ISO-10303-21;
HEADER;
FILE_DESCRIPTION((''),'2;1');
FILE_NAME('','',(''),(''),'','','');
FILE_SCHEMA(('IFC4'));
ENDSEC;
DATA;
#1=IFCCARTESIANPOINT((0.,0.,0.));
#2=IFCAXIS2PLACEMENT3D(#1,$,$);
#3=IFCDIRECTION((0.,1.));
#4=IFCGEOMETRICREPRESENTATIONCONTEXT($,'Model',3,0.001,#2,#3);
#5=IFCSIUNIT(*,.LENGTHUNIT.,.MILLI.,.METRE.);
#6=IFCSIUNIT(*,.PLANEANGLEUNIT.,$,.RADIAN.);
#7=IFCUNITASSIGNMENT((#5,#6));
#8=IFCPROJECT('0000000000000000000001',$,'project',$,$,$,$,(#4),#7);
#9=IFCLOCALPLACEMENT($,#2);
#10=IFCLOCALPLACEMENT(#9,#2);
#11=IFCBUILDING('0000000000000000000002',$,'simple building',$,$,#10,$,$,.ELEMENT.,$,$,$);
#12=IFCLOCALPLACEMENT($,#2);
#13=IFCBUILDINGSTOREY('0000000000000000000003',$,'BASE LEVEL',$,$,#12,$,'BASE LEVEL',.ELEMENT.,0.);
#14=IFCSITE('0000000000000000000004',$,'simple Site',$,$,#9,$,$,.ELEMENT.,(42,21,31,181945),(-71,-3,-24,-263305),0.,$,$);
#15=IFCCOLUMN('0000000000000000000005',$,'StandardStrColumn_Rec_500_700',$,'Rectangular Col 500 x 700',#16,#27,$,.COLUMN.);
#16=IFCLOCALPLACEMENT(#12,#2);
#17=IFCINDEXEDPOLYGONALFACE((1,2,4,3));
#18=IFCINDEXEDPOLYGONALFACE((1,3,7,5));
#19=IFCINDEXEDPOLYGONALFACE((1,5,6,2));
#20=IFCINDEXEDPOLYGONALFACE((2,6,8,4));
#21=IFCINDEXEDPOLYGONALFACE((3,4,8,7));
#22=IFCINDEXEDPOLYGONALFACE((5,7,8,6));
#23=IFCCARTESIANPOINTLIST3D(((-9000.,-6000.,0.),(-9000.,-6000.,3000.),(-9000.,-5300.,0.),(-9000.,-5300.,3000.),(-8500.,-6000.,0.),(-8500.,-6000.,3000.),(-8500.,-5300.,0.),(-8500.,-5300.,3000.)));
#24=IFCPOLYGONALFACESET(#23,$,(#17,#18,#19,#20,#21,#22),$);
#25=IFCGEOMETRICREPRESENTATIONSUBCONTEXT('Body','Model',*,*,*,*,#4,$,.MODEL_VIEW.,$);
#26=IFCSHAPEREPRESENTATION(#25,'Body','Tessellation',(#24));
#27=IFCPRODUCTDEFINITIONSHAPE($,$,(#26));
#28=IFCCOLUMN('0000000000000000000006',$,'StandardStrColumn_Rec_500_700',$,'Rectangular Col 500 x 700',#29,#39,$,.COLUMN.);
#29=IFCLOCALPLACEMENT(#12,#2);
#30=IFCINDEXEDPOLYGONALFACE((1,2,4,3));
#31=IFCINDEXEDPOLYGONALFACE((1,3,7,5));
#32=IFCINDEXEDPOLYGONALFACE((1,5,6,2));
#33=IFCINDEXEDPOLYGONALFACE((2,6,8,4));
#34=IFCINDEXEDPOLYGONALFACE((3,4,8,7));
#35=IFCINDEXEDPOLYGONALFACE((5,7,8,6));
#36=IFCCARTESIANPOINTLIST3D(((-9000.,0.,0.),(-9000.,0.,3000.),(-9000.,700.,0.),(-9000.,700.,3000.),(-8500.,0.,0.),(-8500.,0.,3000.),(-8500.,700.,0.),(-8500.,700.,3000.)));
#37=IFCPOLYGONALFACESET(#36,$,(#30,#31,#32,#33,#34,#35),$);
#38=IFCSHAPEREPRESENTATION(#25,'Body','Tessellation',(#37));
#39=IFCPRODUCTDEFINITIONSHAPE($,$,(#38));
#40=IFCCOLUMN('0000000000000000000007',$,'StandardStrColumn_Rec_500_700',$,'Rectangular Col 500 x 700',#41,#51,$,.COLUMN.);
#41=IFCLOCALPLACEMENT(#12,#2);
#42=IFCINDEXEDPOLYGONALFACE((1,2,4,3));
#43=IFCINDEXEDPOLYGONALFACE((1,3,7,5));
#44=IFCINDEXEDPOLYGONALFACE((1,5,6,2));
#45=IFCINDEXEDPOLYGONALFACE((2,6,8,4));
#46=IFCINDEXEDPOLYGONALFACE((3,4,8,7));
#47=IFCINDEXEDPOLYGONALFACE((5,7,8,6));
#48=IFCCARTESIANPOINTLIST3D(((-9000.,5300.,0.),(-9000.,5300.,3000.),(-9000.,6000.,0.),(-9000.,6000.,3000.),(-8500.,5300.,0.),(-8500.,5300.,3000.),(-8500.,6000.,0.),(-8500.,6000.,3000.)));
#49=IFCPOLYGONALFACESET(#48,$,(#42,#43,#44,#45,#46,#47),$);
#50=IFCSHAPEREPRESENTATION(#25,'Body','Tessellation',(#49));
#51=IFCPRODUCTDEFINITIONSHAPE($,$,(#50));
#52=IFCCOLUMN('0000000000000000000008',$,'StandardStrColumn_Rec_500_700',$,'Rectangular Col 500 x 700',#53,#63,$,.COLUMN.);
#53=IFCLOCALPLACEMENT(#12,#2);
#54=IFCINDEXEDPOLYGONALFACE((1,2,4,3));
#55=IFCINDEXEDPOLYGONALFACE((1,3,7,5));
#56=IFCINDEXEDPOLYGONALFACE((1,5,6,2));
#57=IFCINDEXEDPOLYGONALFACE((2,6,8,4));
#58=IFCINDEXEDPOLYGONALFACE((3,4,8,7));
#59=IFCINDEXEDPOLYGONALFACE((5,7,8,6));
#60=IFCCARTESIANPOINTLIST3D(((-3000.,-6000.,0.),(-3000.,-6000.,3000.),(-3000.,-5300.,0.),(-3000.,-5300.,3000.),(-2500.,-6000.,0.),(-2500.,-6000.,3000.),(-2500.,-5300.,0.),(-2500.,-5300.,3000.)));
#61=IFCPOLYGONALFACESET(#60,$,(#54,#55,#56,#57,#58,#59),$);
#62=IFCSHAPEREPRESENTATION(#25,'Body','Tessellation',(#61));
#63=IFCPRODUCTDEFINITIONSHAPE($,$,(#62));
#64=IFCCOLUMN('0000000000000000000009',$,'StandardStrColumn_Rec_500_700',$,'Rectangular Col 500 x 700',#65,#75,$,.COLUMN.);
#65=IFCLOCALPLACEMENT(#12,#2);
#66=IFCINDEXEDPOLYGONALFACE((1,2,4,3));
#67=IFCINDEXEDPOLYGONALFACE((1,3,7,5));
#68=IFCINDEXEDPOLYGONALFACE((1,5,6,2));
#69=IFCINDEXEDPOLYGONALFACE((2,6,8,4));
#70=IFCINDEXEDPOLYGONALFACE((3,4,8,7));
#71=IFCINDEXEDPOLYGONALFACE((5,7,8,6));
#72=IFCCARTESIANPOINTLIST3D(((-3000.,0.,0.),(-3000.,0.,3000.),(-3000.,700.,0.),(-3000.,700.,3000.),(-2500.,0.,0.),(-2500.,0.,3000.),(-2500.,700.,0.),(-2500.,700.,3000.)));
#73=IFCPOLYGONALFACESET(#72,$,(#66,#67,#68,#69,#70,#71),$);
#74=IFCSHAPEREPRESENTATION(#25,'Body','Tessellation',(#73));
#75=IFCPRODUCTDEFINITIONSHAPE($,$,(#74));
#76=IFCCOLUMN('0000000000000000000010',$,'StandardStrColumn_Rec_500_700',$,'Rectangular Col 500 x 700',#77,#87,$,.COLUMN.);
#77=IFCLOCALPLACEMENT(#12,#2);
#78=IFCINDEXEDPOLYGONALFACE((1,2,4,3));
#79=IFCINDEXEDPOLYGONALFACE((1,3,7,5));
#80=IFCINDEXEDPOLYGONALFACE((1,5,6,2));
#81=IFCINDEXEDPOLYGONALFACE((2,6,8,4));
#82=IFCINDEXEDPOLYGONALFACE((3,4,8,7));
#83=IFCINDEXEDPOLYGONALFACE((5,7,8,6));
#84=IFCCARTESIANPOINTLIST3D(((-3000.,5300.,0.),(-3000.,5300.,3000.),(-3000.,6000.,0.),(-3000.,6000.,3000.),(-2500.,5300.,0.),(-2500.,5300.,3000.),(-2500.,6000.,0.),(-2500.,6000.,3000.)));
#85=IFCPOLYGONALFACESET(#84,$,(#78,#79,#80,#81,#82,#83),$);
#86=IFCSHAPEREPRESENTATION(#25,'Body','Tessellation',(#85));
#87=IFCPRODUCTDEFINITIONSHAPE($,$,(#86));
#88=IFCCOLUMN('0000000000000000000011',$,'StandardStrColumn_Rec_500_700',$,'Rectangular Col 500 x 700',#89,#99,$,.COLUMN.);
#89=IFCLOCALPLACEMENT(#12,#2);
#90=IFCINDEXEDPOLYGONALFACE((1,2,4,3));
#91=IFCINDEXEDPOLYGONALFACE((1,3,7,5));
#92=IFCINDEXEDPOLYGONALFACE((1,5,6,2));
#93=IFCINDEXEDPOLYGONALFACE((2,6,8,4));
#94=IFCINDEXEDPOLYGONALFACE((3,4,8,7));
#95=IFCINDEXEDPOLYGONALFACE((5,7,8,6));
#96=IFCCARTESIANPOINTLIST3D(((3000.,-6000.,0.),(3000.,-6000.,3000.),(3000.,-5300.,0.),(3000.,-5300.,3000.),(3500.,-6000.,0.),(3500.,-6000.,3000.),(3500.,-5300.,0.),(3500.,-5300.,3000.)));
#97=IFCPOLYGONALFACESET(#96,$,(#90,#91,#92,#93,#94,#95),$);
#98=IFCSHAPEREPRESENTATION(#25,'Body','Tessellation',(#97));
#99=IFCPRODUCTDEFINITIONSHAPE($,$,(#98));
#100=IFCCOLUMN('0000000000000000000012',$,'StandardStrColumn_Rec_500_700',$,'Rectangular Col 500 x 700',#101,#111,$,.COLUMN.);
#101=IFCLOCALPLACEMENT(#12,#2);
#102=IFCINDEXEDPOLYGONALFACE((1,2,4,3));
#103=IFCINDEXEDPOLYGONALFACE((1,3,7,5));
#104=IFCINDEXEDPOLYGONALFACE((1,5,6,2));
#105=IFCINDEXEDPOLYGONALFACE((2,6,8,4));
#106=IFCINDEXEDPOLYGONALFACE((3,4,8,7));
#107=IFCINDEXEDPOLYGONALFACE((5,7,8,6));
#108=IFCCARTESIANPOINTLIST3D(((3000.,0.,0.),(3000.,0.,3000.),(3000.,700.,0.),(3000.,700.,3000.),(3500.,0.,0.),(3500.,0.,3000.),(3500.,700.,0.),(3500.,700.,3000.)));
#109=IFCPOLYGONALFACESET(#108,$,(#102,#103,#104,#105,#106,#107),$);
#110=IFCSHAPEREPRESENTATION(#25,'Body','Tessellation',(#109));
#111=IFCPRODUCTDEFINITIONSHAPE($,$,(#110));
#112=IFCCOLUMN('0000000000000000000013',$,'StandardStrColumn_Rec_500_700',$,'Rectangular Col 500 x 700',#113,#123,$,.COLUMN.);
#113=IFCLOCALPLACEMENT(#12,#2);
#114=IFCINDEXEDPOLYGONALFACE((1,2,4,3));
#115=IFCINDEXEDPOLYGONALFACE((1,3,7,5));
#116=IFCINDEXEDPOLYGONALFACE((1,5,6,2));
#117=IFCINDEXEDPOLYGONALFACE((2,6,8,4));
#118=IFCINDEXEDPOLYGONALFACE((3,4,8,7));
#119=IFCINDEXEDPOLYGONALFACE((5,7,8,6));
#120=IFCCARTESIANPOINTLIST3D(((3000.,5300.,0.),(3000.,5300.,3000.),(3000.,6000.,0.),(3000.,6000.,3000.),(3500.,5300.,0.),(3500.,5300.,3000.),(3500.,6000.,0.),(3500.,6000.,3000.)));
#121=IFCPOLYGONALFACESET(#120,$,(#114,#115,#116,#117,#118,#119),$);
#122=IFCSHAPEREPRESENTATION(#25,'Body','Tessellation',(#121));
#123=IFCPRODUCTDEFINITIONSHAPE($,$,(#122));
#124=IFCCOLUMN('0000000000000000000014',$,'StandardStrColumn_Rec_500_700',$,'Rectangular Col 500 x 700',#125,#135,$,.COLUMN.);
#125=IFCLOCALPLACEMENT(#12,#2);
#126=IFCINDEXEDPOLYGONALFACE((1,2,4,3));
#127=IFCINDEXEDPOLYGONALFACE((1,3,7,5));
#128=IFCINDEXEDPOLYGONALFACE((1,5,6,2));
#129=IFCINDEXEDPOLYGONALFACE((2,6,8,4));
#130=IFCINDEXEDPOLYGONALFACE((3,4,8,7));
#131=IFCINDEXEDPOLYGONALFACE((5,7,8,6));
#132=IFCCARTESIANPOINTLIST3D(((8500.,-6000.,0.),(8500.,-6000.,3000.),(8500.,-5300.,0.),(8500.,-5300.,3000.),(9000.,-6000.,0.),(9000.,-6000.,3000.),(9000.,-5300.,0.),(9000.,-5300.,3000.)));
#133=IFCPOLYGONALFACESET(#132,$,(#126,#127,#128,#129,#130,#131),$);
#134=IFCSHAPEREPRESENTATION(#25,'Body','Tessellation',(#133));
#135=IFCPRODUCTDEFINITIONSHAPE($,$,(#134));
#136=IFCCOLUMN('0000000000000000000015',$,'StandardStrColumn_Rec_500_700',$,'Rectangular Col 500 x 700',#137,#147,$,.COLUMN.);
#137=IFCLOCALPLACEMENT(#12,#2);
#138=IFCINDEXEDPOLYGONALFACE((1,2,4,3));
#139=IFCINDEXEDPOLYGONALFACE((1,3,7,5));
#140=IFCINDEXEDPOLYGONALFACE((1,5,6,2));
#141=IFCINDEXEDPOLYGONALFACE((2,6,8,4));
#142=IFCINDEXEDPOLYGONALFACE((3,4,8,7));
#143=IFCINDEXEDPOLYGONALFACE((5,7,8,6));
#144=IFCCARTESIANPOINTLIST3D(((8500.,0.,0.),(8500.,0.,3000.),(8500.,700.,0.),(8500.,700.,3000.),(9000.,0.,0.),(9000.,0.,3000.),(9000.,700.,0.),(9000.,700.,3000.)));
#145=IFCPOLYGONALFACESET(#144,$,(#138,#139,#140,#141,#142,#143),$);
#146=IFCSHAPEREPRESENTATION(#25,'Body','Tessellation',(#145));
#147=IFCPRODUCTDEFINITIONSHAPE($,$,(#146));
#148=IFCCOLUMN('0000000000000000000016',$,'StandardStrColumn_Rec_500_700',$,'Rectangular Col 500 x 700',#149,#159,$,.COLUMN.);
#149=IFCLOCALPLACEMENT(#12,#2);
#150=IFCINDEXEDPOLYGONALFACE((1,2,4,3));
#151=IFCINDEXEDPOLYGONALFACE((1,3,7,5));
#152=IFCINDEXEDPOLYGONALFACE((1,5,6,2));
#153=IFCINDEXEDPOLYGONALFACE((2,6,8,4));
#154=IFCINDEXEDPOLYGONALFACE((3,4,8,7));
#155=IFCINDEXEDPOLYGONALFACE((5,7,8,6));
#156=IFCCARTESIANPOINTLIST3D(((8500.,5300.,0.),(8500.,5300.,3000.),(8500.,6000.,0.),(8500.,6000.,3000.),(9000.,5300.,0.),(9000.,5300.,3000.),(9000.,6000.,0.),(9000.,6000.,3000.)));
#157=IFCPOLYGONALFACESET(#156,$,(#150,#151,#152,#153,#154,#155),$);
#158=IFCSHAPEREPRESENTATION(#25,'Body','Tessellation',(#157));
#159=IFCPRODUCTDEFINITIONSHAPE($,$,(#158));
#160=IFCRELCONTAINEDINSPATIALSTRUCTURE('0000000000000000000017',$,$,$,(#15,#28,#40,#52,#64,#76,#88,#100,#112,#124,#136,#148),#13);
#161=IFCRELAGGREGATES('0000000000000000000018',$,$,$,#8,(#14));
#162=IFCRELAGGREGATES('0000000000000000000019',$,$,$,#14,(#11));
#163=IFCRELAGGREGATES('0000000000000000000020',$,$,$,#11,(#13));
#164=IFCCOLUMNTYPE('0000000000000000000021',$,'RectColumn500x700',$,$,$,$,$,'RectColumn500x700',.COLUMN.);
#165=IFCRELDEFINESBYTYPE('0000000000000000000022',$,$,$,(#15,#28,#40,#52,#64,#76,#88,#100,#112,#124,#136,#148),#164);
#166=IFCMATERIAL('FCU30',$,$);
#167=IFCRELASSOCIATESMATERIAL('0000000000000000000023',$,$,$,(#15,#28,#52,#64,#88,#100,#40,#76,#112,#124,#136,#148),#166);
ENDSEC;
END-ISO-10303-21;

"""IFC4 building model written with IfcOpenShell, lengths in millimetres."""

from ifc_helpers import new_model, si_unit, direction, frame, origin, origin_with_axes, origin_2d_with_axis, place, context, subcontext, project, spatial, rectangle, extrude, material, material_profile, profile_set, profile_usage, type_object, element, save


model = new_model("IFC4")

# Units and contexts
model_context = context("Model", 3, precision=0.001, world=origin(), true_north=direction((0.0, 1.0)))
body_context = subcontext(model_context, "Body", "Model", "MODEL_VIEW")
ifc_project = project(units=[si_unit("LENGTHUNIT", "METRE", prefix="MILLI"), si_unit("PLANEANGLEUNIT", "RADIAN")], contexts=[model_context])

# Site, building, storey
site_placement = place(None, origin())
site = spatial("IfcSite", under=ifc_project, at=site_placement, Name="simple Site", CompositionType="ELEMENT", RefLatitude=(42, 21, 31, 181945), RefLongitude=(-71, -3, -24, -263305), RefElevation=0.0)
building_placement = place(site_placement, origin())
building = spatial("IfcBuilding", under=site, at=building_placement, Name="simple building", CompositionType="ELEMENT")
storey_placement = place(None, origin())
storey = spatial("IfcBuildingStorey", under=building, at=storey_placement, Name="BASE LEVEL", LongName="BASE LEVEL", CompositionType="ELEMENT", Elevation=0.0)

# Columns
ifc_material = material(Name="FCU30")
ifc_material_profile = material_profile(ifc_material, rectangle(XDim=500.0, YDim=700.0, at=origin_2d_with_axis()))
ifc_profile_set = profile_set([ifc_material_profile])
ifc_profile_usage_1 = profile_usage(ifc_profile_set, cardinal=7)
column_type = type_object("IfcColumnType", Name="RectColumn500x700", ElementType="RectColumn500x700", PredefinedType="COLUMN")
for number, where, z_axis, x_axis, name in (
    (1, (-8750.0, -5650.0, 0.0), (0.0, 0.0, 1.0), (1.0, 0.0, 0.0), "StandardStrColumn_Rec_500_700"),
    (2, (-8750.0, 350.0, 0.0), (0.0, 0.0, 1.0), (1.0, 0.0, 0.0), "StandardStrColumn_Rec_500_700"),
):
    element("IfcColumn", number, at=place(None, frame(where, z_axis=z_axis, x_axis=x_axis)), inside=storey, type_object=column_type, material=ifc_profile_usage_1, Name=name, ObjectType="Rectangular Col 500 x 700", PredefinedType="COLUMN", context=body_context, shape_type="SweptSolid", body=[
        extrude(rectangle(XDim=500.0, YDim=700.0, at=origin_2d_with_axis()), origin_with_axes(), (0.0, 0.0, 1.0), 3000.0),
    ])
ifc_profile_usage_2 = profile_usage(ifc_profile_set, cardinal=1)
column_1_placement = place(None, frame((-8750.0, 5650.0, 0.0), z_axis=(0.0, 0.0, 1.0), x_axis=(1.0, 0.0, 0.0)))
element("IfcColumn", 3, at=column_1_placement, inside=storey, type_object=column_type, material=ifc_profile_usage_2, Name="StandardStrColumn_Rec_500_700", ObjectType="Rectangular Col 500 x 700", PredefinedType="COLUMN", context=body_context, shape_type="SweptSolid", body=[
    extrude(rectangle(XDim=500.0, YDim=700.0, at=origin_2d_with_axis()), origin_with_axes(), (0.0, 0.0, 1.0), 3000.0),
])
for number, where, z_axis, x_axis, name in (
    (4, (-2750.0, -5650.0, 0.0), (0.0, 0.0, 1.0), (1.0, 0.0, 0.0), "StandardStrColumn_Rec_500_700"),
    (5, (-2750.0, 350.0, 0.0), (0.0, 0.0, 1.0), (1.0, 0.0, 0.0), "StandardStrColumn_Rec_500_700"),
):
    element("IfcColumn", number, at=place(None, frame(where, z_axis=z_axis, x_axis=x_axis)), inside=storey, type_object=column_type, material=ifc_profile_usage_1, Name=name, ObjectType="Rectangular Col 500 x 700", PredefinedType="COLUMN", context=body_context, shape_type="SweptSolid", body=[
        extrude(rectangle(XDim=500.0, YDim=700.0, at=origin_2d_with_axis()), origin_with_axes(), (0.0, 0.0, 1.0), 3000.0),
    ])
column_2_placement = place(None, frame((-2750.0, 5650.0, 0.0), z_axis=(0.0, 0.0, 1.0), x_axis=(1.0, 0.0, 0.0)))
element("IfcColumn", 6, at=column_2_placement, inside=storey, type_object=column_type, material=ifc_profile_usage_2, Name="StandardStrColumn_Rec_500_700", ObjectType="Rectangular Col 500 x 700", PredefinedType="COLUMN", context=body_context, shape_type="SweptSolid", body=[
    extrude(rectangle(XDim=500.0, YDim=700.0, at=origin_2d_with_axis()), origin_with_axes(), (0.0, 0.0, 1.0), 3000.0),
])
for number, where, z_axis, x_axis, name in (
    (7, (3250.0, -5650.0, 0.0), (0.0, 0.0, 1.0), (1.0, 0.0, 0.0), "StandardStrColumn_Rec_500_700"),
    (8, (3250.0, 350.0, 0.0), (0.0, 0.0, 1.0), (1.0, 0.0, 0.0), "StandardStrColumn_Rec_500_700"),
):
    element("IfcColumn", number, at=place(None, frame(where, z_axis=z_axis, x_axis=x_axis)), inside=storey, type_object=column_type, material=ifc_profile_usage_1, Name=name, ObjectType="Rectangular Col 500 x 700", PredefinedType="COLUMN", context=body_context, shape_type="SweptSolid", body=[
        extrude(rectangle(XDim=500.0, YDim=700.0, at=origin_2d_with_axis()), origin_with_axes(), (0.0, 0.0, 1.0), 3000.0),
    ])
column_3_placement = place(None, frame((3250.0, 5650.0, 0.0), z_axis=(0.0, 0.0, 1.0), x_axis=(1.0, 0.0, 0.0)))
element("IfcColumn", 9, at=column_3_placement, inside=storey, type_object=column_type, material=ifc_profile_usage_2, Name="StandardStrColumn_Rec_500_700", ObjectType="Rectangular Col 500 x 700", PredefinedType="COLUMN", context=body_context, shape_type="SweptSolid", body=[
    extrude(rectangle(XDim=500.0, YDim=700.0, at=origin_2d_with_axis()), origin_with_axes(), (0.0, 0.0, 1.0), 3000.0),
])
ifc_profile_usage_3 = profile_usage(ifc_profile_set, cardinal=9)
for number, where, z_axis, x_axis, name in (
    (10, (8750.0, -5650.0, 0.0), (0.0, 0.0, 1.0), (1.0, 0.0, 0.0), "StandardStrColumn_Rec_500_700"),
    (11, (8750.0, 350.0, 0.0), (0.0, 0.0, 1.0), (1.0, 0.0, 0.0), "StandardStrColumn_Rec_500_700"),
):
    element("IfcColumn", number, at=place(None, frame(where, z_axis=z_axis, x_axis=x_axis)), inside=storey, type_object=column_type, material=ifc_profile_usage_3, Name=name, ObjectType="Rectangular Col 500 x 700", PredefinedType="COLUMN", context=body_context, shape_type="SweptSolid", body=[
        extrude(rectangle(XDim=500.0, YDim=700.0, at=origin_2d_with_axis()), origin_with_axes(), (0.0, 0.0, 1.0), 3000.0),
    ])
ifc_profile_usage_4 = profile_usage(ifc_profile_set, cardinal=3)
column_4_placement = place(None, frame((8750.0, 5650.0, 0.0), z_axis=(0.0, 0.0, 1.0), x_axis=(1.0, 0.0, 0.0)))
element("IfcColumn", 12, at=column_4_placement, inside=storey, type_object=column_type, material=ifc_profile_usage_4, Name="StandardStrColumn_Rec_500_700", ObjectType="Rectangular Col 500 x 700", PredefinedType="COLUMN", context=body_context, shape_type="SweptSolid", body=[
    extrude(rectangle(XDim=500.0, YDim=700.0, at=origin_2d_with_axis()), origin_with_axes(), (0.0, 0.0, 1.0), 3000.0),
])

save(model, "model.ifc")
